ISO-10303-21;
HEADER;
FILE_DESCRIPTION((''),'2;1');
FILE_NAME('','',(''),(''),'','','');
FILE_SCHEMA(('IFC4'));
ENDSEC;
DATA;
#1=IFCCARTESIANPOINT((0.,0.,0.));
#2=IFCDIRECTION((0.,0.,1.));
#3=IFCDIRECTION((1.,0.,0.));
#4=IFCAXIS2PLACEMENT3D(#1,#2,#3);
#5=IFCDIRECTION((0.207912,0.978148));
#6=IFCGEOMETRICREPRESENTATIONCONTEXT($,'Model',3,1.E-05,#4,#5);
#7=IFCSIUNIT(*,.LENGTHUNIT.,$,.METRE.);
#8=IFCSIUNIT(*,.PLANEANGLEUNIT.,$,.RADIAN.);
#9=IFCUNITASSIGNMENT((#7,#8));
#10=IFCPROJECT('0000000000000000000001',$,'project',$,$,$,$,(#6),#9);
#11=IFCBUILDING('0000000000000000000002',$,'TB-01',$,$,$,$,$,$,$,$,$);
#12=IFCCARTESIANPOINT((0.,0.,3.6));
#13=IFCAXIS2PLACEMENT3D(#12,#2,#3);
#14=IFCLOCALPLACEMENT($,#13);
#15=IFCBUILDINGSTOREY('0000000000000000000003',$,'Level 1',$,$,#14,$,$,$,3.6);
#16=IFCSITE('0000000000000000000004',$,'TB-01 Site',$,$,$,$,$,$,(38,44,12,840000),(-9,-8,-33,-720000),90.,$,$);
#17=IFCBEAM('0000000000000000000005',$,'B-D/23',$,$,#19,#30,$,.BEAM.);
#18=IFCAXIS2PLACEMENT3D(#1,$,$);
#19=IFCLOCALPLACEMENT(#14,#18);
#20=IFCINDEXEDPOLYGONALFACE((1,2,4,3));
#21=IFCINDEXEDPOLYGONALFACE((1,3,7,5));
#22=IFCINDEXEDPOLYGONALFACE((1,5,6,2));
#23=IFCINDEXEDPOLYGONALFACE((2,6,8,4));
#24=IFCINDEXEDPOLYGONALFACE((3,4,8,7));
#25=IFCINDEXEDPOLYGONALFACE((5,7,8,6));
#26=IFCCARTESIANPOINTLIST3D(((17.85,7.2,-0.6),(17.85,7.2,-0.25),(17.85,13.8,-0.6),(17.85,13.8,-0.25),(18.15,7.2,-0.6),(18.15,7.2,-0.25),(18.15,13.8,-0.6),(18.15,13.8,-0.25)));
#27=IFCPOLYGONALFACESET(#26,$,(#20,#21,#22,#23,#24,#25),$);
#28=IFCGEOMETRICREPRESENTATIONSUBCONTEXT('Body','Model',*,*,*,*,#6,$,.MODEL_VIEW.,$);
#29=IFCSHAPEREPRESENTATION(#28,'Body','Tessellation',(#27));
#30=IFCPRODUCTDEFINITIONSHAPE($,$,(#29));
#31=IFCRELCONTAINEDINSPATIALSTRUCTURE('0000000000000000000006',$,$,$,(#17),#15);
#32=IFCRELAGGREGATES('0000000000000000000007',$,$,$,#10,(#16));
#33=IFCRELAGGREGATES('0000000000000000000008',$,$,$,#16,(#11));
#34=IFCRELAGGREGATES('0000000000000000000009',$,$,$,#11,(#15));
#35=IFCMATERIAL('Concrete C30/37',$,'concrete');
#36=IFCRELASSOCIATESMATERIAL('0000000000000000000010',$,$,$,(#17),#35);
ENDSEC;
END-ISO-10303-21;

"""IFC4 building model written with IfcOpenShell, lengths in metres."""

from ifc_helpers import new_model, si_unit, direction, frame, origin_with_axes, place, context, subcontext, project, spatial, rectangle, extrude, material, element, save


model = new_model("IFC4")

# Units and contexts
model_context = context("Model", 3, precision=1e-05, world=origin_with_axes(), true_north=direction((0.207912, 0.978148)))
body_context = subcontext(model_context, "Body", "Model", "MODEL_VIEW")
ifc_project = project(units=[si_unit("LENGTHUNIT", "METRE"), si_unit("PLANEANGLEUNIT", "RADIAN")], contexts=[model_context])

# Site, building, storey
site = spatial("IfcSite", under=ifc_project, Name="TB-01 Site", RefLatitude=(38, 44, 12, 840000), RefLongitude=(-9, -8, -33, -720000), RefElevation=90.0)
building = spatial("IfcBuilding", under=site, Name="TB-01")
storey_placement = place(None, frame((0.0, 0.0, 3.6), z_axis=(0.0, 0.0, 1.0), x_axis=(1.0, 0.0, 0.0)))
storey = spatial("IfcBuildingStorey", under=building, at=storey_placement, Name="Level 1", Elevation=3.6)

# Beam
ifc_material = material(Name="Concrete C30/37", Category="concrete")
beam_1_placement = place(storey_placement, frame((18.0, 7.2, -0.425), z_axis=(0.0, 1.0, 0.0), x_axis=(-1.0, 0.0, 0.0)))
element("IfcBeam", 1, at=beam_1_placement, inside=storey, material=ifc_material, Name="B-D/23", PredefinedType="BEAM", context=body_context, shape_type="SweptSolid", body=[
    extrude(rectangle(XDim=0.3, YDim=0.35), origin_with_axes(), (0.0, 0.0, 1.0), 6.6),
])

save(model, "model.ifc")
